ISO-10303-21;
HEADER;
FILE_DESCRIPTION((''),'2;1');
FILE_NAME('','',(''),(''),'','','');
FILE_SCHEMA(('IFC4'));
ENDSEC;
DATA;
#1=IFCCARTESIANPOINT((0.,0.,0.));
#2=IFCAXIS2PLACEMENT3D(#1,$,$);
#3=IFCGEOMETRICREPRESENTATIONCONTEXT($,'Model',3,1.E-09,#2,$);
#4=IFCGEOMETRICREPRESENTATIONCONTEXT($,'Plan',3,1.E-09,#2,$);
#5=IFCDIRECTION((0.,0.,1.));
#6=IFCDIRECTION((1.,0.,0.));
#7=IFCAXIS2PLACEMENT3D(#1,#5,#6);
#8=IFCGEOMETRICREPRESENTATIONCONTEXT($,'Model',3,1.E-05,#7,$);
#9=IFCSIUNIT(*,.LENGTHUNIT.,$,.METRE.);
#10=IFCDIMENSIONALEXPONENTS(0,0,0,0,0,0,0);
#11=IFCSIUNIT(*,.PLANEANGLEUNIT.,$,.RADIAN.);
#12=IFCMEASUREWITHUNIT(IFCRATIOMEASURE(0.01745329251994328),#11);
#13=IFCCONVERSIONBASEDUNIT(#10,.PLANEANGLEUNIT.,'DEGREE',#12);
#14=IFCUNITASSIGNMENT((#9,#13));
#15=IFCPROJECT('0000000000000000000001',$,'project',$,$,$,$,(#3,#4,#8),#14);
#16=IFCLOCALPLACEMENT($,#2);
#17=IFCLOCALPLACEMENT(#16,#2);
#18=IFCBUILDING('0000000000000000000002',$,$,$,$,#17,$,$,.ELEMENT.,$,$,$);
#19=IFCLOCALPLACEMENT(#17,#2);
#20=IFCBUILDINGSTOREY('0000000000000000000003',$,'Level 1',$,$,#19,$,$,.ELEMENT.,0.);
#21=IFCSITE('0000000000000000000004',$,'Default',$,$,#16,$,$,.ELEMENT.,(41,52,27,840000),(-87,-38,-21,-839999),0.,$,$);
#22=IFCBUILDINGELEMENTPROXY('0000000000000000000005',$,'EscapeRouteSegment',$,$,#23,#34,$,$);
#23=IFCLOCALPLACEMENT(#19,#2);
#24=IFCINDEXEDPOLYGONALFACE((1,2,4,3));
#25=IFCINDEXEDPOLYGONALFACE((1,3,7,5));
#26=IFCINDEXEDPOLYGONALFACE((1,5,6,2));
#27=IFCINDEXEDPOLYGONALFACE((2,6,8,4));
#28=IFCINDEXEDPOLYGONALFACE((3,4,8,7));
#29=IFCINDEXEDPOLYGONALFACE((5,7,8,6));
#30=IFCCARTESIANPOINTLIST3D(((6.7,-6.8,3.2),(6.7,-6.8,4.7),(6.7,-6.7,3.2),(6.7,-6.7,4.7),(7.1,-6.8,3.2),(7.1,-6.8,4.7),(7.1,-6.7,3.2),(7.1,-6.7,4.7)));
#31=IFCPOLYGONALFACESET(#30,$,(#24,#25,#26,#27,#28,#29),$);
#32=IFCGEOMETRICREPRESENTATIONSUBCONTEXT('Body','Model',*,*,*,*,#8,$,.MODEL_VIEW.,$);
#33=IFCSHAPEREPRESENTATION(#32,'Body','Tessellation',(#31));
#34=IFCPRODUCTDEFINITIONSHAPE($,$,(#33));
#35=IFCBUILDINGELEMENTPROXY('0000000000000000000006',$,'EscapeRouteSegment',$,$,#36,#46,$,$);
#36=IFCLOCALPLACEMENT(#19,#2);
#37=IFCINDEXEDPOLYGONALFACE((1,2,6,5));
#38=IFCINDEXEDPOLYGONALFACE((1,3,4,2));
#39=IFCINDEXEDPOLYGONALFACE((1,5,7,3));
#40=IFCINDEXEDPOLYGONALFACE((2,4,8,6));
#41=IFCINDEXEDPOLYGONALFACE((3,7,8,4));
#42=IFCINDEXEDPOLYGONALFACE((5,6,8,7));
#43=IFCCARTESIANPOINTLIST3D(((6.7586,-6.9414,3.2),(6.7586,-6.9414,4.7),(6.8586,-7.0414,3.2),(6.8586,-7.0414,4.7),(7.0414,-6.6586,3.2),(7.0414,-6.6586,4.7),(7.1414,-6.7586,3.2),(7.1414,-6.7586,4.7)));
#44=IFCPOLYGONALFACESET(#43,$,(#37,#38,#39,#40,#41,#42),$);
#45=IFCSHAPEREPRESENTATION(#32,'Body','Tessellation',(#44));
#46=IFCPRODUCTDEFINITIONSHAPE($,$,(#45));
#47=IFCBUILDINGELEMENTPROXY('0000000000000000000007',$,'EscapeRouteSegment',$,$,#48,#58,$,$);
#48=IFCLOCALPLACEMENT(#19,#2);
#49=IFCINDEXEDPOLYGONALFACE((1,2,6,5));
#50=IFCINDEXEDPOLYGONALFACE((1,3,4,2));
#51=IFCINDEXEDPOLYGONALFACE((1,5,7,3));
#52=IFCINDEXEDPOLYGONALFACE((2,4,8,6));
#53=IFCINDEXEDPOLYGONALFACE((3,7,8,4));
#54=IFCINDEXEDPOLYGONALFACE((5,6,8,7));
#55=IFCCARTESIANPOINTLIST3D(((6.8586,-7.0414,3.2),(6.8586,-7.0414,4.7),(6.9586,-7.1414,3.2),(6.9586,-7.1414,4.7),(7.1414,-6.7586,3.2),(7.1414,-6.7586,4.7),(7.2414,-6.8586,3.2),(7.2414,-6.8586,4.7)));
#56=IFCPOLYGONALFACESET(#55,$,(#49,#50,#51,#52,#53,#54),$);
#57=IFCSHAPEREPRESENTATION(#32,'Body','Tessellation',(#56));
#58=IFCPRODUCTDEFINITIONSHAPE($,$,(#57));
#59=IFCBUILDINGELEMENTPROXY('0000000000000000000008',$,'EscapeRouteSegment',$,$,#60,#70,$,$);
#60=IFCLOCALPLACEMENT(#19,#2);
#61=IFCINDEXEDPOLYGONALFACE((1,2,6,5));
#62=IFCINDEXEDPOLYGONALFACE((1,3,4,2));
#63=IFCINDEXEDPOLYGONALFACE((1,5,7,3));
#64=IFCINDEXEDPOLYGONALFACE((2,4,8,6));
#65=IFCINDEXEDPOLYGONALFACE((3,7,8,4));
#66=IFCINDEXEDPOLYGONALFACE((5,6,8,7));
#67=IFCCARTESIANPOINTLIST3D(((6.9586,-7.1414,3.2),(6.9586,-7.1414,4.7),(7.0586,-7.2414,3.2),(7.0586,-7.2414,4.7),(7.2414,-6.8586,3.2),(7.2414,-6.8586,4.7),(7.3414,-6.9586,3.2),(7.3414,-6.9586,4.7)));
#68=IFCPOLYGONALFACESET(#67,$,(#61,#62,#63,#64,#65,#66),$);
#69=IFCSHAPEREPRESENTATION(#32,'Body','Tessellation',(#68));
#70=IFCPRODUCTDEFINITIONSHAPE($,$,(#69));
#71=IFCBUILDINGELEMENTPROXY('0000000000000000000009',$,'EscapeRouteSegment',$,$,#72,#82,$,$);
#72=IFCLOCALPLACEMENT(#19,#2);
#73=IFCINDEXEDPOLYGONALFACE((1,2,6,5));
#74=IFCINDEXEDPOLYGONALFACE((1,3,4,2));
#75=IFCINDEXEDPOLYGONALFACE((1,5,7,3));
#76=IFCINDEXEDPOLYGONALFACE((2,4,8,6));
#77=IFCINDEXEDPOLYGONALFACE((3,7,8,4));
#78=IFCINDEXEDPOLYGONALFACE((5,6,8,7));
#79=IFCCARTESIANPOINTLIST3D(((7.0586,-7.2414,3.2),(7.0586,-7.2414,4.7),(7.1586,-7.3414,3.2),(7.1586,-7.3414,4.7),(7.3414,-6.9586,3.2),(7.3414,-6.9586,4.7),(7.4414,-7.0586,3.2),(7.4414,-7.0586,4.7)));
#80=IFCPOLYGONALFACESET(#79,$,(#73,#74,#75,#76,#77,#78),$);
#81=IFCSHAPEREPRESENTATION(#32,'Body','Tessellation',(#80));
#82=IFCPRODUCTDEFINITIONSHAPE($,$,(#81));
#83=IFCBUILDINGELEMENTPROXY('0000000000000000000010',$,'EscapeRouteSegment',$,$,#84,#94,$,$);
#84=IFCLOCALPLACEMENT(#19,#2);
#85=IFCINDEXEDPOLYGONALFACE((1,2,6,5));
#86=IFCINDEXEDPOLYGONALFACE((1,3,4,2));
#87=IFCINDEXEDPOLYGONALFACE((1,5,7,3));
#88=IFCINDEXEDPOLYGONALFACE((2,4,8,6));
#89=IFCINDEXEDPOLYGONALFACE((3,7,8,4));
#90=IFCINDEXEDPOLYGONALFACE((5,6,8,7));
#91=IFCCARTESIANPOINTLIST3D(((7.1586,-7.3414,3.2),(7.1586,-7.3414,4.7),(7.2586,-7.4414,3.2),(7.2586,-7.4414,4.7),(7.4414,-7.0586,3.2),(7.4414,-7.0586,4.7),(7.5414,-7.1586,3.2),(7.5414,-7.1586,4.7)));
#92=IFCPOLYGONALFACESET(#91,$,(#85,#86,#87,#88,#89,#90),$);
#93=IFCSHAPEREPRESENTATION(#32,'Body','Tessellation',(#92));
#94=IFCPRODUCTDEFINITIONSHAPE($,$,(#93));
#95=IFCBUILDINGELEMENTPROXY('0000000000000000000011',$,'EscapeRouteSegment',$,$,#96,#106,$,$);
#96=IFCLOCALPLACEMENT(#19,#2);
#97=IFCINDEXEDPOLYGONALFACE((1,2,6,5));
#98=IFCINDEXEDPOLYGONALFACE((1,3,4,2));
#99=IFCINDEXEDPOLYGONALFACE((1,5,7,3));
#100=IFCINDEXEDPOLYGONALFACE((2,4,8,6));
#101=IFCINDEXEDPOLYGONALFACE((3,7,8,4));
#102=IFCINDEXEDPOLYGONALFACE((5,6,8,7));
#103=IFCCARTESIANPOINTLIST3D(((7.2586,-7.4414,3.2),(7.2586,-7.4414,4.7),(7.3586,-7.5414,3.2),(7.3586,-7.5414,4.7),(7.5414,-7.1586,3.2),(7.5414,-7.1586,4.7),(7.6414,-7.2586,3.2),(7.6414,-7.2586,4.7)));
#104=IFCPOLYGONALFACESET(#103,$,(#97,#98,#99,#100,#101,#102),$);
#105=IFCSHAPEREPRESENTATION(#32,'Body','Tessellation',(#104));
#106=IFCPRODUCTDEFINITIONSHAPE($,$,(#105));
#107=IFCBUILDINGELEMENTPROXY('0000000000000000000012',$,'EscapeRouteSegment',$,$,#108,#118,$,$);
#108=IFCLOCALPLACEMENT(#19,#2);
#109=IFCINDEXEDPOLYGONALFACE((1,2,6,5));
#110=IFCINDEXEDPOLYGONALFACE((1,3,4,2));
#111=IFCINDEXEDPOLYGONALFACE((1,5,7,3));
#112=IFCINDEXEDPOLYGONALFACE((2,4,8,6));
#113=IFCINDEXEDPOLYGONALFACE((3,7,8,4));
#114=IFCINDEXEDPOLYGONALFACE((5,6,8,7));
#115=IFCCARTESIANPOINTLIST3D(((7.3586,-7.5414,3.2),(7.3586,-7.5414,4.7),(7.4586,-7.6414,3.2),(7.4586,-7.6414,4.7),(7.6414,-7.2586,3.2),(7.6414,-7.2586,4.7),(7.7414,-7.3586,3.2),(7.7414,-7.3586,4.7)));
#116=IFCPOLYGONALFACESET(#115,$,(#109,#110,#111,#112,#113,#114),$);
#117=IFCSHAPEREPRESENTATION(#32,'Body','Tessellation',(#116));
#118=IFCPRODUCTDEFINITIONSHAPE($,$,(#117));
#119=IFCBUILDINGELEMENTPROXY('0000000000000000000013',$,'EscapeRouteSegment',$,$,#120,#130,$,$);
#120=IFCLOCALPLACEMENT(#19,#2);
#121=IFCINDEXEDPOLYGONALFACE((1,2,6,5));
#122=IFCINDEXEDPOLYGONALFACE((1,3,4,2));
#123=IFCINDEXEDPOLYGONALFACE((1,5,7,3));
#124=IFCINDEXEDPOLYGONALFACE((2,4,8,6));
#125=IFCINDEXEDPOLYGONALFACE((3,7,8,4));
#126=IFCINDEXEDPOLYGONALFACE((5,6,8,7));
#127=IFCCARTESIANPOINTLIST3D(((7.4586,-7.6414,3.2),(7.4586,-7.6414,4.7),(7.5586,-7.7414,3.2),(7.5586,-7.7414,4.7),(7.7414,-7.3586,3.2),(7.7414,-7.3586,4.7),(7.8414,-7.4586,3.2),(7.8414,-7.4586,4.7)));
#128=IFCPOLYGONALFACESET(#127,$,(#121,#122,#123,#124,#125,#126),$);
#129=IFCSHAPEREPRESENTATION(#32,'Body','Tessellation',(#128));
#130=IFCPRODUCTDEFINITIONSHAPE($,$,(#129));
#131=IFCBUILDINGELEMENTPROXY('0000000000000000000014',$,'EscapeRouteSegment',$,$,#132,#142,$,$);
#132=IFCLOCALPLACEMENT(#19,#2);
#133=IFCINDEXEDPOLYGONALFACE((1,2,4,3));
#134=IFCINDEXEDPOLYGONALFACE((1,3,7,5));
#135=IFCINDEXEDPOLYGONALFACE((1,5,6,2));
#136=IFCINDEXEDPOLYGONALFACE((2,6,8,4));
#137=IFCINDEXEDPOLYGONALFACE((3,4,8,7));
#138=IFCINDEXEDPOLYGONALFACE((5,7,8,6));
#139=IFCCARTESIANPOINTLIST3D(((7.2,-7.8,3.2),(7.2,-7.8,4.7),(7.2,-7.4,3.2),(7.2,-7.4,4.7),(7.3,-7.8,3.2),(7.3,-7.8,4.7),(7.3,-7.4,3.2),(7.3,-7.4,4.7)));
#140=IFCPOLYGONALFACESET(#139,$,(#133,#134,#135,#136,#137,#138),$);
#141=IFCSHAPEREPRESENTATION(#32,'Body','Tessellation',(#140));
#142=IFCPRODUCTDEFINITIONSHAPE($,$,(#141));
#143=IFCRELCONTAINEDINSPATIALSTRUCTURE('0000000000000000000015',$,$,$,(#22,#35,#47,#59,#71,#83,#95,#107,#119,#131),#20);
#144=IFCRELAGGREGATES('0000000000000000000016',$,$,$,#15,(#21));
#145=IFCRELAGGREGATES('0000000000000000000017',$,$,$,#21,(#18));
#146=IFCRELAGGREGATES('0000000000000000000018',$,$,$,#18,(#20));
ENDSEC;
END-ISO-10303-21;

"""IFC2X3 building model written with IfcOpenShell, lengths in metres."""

from ifc_helpers import new_model, entity, si_unit, converted_unit, frame, origin, origin_with_axes, place, context, subcontext, project, spatial, polyline, outline, extrude, element, save


model = new_model("IFC2X3")

# Units and contexts
model_context_1 = context("Model", 3, precision=1e-09, world=origin())
plan_context = context("Plan", 3, precision=1e-09, world=origin())
model_context_2 = context("Model", 3, precision=1e-05, world=origin_with_axes())
body_context = subcontext(model_context_2, "Body", "Model", "MODEL_VIEW")
ifc_project = project(units=[si_unit("LENGTHUNIT", "METRE"), converted_unit("PLANEANGLEUNIT", "DEGREE", entity("IfcRatioMeasure", 0.01745329251994328), si_unit("PLANEANGLEUNIT", "RADIAN"), dimensions=[0, 0, 0, 0, 0, 0, 0])], contexts=[model_context_1, plan_context, model_context_2])

# Site, building, storey
site_placement = place(None, origin())
site = spatial("IfcSite", under=ifc_project, at=site_placement, Name="Default", CompositionType="ELEMENT", RefLatitude=(41, 52, 27, 840000), RefLongitude=(-87, -38, -21, -839999), RefElevation=0.0)
building_placement = place(site_placement, origin())
building = spatial("IfcBuilding", under=site, at=building_placement, CompositionType="ELEMENT")
storey_placement = place(building_placement, origin())
storey = spatial("IfcBuildingStorey", under=building, at=storey_placement, Name="Level 1", CompositionType="ELEMENT", Elevation=0.0)

# Building element proxies
proxy_1_placement = place(storey_placement, frame((6.9, -6.7, 3.2), z_axis=(0.0, 0.0, 1.0), x_axis=(0.0, -1.0, 0.0)))
element("IfcBuildingElementProxy", 1, at=proxy_1_placement, inside=storey, Name="EscapeRouteSegment", context=body_context, shape_type="SweptSolid", body=[
    extrude(outline(polyline([(0.0, -0.2), (0.0, 0.2), (0.1, 0.2), (0.1, -0.2), (0.0, -0.2)])), origin_with_axes(), (0.0, 0.0, 1.0), 1.5),
])
for number, where, z_axis, x_axis, name in (
    (2, (6.9, -6.8, 3.2), (0.0, 0.0, 1.0), (0.707107, -0.707107, 0.0), "EscapeRouteSegment"),
    (3, (7.0, -6.9, 3.2), (0.0, 0.0, 1.0), (0.707107, -0.707107, 0.0), "EscapeRouteSegment"),
    (4, (7.1, -7.0, 3.2), (0.0, 0.0, 1.0), (0.707107, -0.707107, 0.0), "EscapeRouteSegment"),
):
    element("IfcBuildingElementProxy", number, at=place(storey_placement, frame(where, z_axis=z_axis, x_axis=x_axis)), inside=storey, Name=name, context=body_context, shape_type="SweptSolid", body=[
        extrude(outline(polyline([(0.0, -0.2), (0.0, 0.2), (0.1414, 0.2), (0.1414, -0.2), (0.0, -0.2)])), origin_with_axes(), (0.0, 0.0, 1.0), 1.5),
    ])
for number, where, z_axis, x_axis, name in (
    (5, (7.2, -7.1, 3.2), (0.0, 0.0, 1.0), (0.707108, -0.707105, 0.0), "EscapeRouteSegment"),
    (6, (7.3, -7.2, 3.2), (0.0, 0.0, 1.0), (0.707105, -0.707108, 0.0), "EscapeRouteSegment"),
):
    element("IfcBuildingElementProxy", number, at=place(storey_placement, frame(where, z_axis=z_axis, x_axis=x_axis)), inside=storey, Name=name, context=body_context, shape_type="SweptSolid", body=[
        extrude(outline(polyline([(0.0, -0.2), (0.0, 0.2), (0.1414, 0.2), (0.1414, -0.2), (0.0, -0.2)])), origin_with_axes(), (0.0, 0.0, 1.0), 1.5),
    ])
for number, where, z_axis, x_axis, name in (
    (7, (7.4, -7.3, 3.2), (0.0, 0.0, 1.0), (0.707107, -0.707107, 0.0), "EscapeRouteSegment"),
    (8, (7.5, -7.4, 3.2), (0.0, 0.0, 1.0), (0.707107, -0.707107, 0.0), "EscapeRouteSegment"),
    (9, (7.6, -7.5, 3.2), (0.0, 0.0, 1.0), (0.707107, -0.707107, 0.0), "EscapeRouteSegment"),
):
    element("IfcBuildingElementProxy", number, at=place(storey_placement, frame(where, z_axis=z_axis, x_axis=x_axis)), inside=storey, Name=name, context=body_context, shape_type="SweptSolid", body=[
        extrude(outline(polyline([(0.0, -0.2), (0.0, 0.2), (0.1414, 0.2), (0.1414, -0.2), (0.0, -0.2)])), origin_with_axes(), (0.0, 0.0, 1.0), 1.5),
    ])
proxy_2_placement = place(storey_placement, frame((7.2, -7.6, 3.2), z_axis=(0.0, 0.0, 1.0), x_axis=(1.0, 0.0, 0.0)))
element("IfcBuildingElementProxy", 10, at=proxy_2_placement, inside=storey, Name="EscapeRouteSegment", context=body_context, shape_type="SweptSolid", body=[
    extrude(outline(polyline([(0.0, -0.2), (0.0, 0.2), (0.1, 0.2), (0.1, -0.2), (0.0, -0.2)])), origin_with_axes(), (0.0, 0.0, 1.0), 1.5),
])

save(model, "model.ifc")
